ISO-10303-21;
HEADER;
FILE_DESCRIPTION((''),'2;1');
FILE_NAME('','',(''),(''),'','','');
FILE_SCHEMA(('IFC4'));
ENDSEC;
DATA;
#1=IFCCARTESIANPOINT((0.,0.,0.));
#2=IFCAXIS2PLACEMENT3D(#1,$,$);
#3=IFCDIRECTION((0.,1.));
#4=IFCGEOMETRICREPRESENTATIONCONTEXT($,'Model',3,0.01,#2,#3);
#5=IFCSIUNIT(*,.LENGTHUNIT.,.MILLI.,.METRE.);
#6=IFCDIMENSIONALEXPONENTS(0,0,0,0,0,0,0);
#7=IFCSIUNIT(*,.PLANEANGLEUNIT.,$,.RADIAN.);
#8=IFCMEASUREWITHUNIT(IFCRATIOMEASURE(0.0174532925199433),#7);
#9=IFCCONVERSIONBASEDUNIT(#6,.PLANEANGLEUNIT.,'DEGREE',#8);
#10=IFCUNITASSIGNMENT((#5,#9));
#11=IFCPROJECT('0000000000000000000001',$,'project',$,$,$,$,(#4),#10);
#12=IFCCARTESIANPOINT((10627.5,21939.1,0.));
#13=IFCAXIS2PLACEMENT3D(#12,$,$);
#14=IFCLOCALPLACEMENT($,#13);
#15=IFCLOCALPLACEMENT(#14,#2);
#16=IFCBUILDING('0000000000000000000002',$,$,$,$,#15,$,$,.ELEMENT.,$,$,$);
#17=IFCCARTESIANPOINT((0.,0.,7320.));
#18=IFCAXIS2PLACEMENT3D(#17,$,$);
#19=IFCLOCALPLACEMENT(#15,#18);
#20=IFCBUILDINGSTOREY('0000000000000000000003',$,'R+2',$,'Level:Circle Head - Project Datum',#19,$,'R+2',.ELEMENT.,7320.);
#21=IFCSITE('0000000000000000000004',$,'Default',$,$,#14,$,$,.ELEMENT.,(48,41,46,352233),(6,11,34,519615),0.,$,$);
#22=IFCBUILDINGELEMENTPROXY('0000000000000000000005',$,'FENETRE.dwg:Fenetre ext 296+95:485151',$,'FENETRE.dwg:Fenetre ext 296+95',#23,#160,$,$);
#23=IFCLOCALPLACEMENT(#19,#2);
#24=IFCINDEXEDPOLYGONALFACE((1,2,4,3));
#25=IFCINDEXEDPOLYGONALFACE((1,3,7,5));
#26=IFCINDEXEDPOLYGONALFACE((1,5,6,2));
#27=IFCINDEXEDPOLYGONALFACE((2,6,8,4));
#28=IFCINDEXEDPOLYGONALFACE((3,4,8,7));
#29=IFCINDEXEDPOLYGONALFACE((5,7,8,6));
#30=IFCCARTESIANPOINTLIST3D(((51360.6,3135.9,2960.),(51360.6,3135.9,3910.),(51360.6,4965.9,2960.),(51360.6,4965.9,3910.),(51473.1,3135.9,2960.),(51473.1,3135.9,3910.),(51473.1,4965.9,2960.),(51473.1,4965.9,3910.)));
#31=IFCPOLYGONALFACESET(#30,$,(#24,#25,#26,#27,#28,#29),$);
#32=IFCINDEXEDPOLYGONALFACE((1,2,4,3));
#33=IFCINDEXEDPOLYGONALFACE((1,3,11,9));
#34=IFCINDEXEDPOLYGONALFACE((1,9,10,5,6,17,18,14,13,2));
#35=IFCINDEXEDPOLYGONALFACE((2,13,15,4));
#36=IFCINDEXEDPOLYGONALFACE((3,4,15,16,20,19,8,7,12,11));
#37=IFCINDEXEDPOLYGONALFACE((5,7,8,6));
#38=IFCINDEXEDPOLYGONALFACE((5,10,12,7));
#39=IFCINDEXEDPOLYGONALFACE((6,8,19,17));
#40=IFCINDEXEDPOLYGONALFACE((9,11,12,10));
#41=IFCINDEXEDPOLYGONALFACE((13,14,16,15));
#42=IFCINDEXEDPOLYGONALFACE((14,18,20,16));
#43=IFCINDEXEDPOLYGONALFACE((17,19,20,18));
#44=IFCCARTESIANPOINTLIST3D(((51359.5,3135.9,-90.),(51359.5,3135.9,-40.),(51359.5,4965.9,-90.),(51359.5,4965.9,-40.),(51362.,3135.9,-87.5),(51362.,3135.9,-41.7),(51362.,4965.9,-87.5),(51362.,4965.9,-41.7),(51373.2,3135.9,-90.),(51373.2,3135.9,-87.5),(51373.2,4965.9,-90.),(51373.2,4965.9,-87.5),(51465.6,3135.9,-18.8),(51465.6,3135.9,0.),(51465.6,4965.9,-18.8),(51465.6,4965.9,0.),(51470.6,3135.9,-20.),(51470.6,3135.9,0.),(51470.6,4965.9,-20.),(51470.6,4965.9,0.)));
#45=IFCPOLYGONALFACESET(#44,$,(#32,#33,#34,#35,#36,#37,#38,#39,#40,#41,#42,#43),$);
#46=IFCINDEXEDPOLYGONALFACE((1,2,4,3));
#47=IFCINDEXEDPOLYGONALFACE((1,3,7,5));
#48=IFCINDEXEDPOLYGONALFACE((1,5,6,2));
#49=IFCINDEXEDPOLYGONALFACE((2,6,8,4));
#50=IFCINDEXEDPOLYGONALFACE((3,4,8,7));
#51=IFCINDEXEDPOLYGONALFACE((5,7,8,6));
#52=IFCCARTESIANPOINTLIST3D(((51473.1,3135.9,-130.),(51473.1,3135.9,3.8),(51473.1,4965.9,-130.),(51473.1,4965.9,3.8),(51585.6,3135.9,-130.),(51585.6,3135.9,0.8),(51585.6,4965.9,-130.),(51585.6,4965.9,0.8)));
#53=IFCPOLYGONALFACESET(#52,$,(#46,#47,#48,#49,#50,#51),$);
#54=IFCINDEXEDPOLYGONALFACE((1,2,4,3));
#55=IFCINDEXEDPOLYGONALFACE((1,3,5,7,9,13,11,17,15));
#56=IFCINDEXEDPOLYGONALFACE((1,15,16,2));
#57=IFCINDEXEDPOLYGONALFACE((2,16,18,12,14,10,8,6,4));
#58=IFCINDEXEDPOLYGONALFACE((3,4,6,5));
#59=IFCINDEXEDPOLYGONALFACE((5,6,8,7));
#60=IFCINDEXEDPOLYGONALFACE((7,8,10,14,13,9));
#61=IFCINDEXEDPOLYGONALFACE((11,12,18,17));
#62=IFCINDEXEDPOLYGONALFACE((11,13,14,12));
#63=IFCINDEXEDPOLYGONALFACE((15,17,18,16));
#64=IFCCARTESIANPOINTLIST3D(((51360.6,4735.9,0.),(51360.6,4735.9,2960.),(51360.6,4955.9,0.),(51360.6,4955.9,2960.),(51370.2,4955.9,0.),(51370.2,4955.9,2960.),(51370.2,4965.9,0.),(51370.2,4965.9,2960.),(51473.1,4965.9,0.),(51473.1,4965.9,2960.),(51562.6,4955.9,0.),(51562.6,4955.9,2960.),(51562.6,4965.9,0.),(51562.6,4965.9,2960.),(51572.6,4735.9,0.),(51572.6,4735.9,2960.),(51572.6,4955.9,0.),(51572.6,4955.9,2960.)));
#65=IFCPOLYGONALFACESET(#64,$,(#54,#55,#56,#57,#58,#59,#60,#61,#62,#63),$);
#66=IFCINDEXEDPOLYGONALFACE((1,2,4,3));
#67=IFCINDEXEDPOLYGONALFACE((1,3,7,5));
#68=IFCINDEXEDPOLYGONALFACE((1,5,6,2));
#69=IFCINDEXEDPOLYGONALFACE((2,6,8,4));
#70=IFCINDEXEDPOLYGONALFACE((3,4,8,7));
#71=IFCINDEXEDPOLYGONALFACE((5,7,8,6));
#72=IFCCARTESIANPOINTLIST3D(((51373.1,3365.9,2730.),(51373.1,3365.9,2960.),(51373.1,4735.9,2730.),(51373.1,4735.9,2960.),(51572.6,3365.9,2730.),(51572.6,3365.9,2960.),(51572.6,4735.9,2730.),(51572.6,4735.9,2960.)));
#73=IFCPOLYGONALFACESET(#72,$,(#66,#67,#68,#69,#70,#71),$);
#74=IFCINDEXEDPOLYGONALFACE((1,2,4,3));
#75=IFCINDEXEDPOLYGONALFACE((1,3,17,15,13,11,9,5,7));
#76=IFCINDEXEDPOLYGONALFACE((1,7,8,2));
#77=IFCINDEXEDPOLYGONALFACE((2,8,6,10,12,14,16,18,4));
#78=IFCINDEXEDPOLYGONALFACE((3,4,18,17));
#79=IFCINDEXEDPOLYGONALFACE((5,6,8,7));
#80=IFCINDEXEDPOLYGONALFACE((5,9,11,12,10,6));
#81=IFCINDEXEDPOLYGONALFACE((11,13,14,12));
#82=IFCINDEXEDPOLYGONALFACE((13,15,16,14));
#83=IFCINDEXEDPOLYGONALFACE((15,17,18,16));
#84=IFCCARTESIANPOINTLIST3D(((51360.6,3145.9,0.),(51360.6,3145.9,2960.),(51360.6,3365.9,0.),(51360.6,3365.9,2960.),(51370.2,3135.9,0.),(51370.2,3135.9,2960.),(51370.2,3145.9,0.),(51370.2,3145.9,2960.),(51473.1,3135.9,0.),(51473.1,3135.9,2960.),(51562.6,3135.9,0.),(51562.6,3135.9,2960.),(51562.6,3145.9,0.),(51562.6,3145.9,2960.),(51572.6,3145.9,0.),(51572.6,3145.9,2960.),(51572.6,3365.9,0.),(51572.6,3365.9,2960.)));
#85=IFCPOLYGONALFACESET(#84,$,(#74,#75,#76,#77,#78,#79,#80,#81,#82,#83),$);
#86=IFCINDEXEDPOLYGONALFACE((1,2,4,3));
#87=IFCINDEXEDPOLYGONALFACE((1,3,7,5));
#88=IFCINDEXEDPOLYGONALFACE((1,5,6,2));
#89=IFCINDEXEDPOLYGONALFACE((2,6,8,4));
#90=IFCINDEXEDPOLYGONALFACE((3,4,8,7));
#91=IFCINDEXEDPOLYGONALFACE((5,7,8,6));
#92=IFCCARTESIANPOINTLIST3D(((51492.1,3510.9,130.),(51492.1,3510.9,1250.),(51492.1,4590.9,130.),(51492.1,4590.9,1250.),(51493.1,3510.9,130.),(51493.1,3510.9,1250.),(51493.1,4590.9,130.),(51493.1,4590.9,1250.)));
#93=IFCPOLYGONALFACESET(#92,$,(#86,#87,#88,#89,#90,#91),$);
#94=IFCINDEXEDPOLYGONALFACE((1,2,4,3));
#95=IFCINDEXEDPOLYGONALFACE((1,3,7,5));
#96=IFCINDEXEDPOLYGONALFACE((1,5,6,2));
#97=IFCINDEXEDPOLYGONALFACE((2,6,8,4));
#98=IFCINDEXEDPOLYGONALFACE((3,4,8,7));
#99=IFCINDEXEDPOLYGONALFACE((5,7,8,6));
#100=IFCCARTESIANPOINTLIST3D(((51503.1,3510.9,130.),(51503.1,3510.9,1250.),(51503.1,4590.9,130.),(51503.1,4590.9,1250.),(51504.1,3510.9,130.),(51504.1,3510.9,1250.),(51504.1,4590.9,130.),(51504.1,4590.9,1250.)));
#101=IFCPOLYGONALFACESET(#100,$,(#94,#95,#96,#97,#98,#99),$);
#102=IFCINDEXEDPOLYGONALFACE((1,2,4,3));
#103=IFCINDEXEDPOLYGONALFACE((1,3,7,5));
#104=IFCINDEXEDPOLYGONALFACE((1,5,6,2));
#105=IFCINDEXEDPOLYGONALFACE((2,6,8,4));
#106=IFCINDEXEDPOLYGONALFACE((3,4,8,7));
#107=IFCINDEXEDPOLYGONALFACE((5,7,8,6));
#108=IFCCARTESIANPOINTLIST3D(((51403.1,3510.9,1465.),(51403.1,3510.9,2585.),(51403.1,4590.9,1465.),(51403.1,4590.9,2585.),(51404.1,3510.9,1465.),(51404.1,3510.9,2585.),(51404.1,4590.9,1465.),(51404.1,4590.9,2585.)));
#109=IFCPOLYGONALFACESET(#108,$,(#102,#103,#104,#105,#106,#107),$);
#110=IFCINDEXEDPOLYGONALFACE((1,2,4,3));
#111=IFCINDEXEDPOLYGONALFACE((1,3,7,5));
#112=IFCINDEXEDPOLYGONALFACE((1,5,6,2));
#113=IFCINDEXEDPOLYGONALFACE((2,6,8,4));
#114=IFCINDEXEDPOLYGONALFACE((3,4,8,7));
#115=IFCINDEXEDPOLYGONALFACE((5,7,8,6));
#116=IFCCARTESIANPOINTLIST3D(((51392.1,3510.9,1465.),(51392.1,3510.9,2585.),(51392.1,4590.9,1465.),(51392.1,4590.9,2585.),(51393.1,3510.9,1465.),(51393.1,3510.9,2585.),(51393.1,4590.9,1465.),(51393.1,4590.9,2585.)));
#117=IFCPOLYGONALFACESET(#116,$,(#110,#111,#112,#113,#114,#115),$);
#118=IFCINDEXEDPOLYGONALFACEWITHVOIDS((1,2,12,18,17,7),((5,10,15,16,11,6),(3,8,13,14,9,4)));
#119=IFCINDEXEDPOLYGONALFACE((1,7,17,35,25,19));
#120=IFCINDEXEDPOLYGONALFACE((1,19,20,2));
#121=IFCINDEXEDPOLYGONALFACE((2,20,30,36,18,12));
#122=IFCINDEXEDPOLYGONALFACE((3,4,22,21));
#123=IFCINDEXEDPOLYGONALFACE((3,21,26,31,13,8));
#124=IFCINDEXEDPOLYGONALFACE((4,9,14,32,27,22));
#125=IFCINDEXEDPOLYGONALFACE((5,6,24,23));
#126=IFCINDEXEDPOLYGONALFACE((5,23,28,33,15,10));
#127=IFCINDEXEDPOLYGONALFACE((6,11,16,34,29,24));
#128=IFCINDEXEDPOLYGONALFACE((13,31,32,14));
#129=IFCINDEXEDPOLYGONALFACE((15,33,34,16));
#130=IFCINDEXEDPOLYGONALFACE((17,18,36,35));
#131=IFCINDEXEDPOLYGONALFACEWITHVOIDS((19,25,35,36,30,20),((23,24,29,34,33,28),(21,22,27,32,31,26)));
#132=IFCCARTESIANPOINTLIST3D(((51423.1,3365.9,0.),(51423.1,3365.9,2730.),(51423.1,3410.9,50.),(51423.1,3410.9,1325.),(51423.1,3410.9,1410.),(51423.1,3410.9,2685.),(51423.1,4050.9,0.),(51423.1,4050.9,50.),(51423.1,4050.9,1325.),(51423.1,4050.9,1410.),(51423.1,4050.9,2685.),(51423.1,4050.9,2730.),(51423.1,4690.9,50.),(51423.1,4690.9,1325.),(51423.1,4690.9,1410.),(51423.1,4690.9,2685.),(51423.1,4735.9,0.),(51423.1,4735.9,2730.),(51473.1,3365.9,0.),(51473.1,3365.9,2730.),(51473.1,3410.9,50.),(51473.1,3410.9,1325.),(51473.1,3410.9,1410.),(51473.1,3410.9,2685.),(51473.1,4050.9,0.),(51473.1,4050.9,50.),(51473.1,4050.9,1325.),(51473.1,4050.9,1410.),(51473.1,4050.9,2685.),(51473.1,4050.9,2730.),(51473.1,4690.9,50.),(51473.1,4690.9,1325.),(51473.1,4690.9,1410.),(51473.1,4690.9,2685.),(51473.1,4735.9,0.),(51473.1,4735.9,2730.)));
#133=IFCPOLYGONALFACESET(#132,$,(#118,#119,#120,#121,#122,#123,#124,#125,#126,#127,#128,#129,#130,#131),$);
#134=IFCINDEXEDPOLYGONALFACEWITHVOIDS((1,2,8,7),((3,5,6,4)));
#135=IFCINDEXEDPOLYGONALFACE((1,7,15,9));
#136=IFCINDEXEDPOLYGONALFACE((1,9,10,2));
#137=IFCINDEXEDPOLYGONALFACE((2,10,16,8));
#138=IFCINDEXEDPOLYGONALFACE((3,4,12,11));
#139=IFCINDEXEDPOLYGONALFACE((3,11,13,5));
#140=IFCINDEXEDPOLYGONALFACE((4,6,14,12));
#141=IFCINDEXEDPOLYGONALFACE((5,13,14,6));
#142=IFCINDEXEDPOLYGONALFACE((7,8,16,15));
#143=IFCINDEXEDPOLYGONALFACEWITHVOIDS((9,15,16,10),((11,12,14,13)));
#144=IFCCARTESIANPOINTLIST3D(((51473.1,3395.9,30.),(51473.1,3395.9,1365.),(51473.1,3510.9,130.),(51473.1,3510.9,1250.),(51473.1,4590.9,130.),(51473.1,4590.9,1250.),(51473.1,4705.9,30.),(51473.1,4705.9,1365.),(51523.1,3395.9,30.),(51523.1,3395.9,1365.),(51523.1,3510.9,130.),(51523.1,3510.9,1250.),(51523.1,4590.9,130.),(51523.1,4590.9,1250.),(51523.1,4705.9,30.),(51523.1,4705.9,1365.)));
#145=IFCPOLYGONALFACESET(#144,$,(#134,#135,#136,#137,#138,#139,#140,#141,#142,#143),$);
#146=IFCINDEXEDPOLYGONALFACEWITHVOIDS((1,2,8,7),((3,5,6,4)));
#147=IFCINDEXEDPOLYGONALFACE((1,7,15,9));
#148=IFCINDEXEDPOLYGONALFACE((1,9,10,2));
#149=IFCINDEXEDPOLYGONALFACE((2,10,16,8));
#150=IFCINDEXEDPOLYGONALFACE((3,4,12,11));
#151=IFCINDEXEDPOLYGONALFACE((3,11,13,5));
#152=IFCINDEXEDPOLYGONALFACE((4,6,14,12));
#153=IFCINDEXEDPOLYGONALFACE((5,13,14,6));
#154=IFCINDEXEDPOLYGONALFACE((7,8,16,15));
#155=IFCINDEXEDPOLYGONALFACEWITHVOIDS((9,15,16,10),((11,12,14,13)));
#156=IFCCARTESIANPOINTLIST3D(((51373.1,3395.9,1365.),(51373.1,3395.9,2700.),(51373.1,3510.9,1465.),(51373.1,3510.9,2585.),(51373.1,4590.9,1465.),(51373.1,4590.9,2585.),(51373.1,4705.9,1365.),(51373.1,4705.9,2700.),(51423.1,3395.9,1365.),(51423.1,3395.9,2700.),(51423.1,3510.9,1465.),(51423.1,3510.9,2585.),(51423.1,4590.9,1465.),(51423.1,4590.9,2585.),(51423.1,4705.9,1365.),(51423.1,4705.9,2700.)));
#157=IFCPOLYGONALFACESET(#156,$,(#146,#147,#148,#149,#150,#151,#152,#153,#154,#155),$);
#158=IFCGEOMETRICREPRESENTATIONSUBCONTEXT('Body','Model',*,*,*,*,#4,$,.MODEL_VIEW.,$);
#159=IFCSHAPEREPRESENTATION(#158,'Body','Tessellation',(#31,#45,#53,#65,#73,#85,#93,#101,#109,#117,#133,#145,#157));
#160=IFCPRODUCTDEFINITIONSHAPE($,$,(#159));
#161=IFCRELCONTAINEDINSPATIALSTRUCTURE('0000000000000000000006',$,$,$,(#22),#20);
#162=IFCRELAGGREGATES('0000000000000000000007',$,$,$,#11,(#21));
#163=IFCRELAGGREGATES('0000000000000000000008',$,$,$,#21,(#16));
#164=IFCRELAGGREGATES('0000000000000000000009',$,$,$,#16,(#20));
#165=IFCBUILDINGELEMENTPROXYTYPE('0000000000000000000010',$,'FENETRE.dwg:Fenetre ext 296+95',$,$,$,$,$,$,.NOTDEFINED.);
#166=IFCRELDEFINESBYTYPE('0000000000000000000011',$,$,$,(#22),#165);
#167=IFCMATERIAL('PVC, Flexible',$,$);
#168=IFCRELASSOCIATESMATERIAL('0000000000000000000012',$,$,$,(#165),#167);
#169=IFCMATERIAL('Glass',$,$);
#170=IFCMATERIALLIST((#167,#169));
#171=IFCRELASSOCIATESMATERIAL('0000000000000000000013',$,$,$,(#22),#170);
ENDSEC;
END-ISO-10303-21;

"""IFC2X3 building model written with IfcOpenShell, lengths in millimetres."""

from ifc_helpers import new_model, entity, si_unit, converted_unit, direction, frame, frame_2d, origin, origin_2d_with_axis, place, context, subcontext, project, spatial, polyline, rectangle, outline, extrude, source, transform, mapped, material, material_list, type_object, type_shapes, element, save


model = new_model("IFC2X3")

# Units and contexts
model_context = context("Model", 3, precision=0.01, world=origin(), true_north=direction((0.0, 1.0)))
body_context = subcontext(model_context, "Body", "Model", "MODEL_VIEW")
ifc_project = project(units=[si_unit("LENGTHUNIT", "METRE", prefix="MILLI"), converted_unit("PLANEANGLEUNIT", "DEGREE", entity("IfcRatioMeasure", 0.0174532925199433), si_unit("PLANEANGLEUNIT", "RADIAN"), dimensions=[0, 0, 0, 0, 0, 0, 0])], contexts=[model_context])

# Site, building, storey
site_placement = place(None, frame((10627.5, 21939.1, 0.0)))
site = spatial("IfcSite", under=ifc_project, at=site_placement, Name="Default", CompositionType="ELEMENT", RefLatitude=(48, 41, 46, 352233), RefLongitude=(6, 11, 34, 519615), RefElevation=0.0)
building_placement = place(site_placement, origin())
building = spatial("IfcBuilding", under=site, at=building_placement, CompositionType="ELEMENT")
storey_placement = place(building_placement, frame((0.0, 0.0, 7320.0)))
storey = spatial("IfcBuildingStorey", under=building, at=storey_placement, Name="R+2", ObjectType="Level:Circle Head - Project Datum", LongName="R+2", CompositionType="ELEMENT", Elevation=7320.0)

# Building element proxy
ifc_material_1 = material(Name="PVC, Flexible")
ifc_material_2 = material(Name="Glass")
building_element_proxy_type_1 = type_object("IfcBuildingElementProxyType", Name="FENETRE.dwg:Fenetre ext 296+95", PredefinedType="NOTDEFINED", material=ifc_material_1)
shared_shape_1 = source(origin(), body_context, "Body", "SweptSolid", [
    extrude(rectangle(XDim=1830.0, YDim=112.5, at=origin_2d_with_axis()), frame((-10.4, 56.3, 2960.0), z_axis=(0.0, 0.0, 1.0), x_axis=(-1.0, 0.0, 0.0)), (0.0, 0.0, 1.0), 950.0),
    extrude(outline(polyline([(-68.6, -14.4), (-72.5, -34.0), (-67.6, -35.0), (-63.9, -16.6), (44.3, -16.6), (54.1, 32.5), (40.6, 35.2), (40.1, 32.7), (51.2, 30.5), (42.2, -14.4), (-68.6, -14.4)])), frame((-925.4, 66.9, -47.5), z_axis=(-1.0, 0.0, 0.0), x_axis=(0.0, 0.980599, -0.196027)), (0.0, 0.0, -1.0), 1830.0),
    extrude(outline(polyline([(-64.7, -56.3), (66.2, -56.3), (66.2, 56.3), (-67.7, 56.3), (-64.7, -56.3)])), frame((-925.4, -56.3, -63.8), z_axis=(1.0, 0.0, 0.0), x_axis=(0.0, 0.0, -1.0)), (0.0, 0.0, 1.0), 1830.0),
    extrude(outline(polyline([(-55.6, 97.0), (-55.6, -5.9), (-55.6, -95.4), (-45.6, -95.4), (-45.6, -105.4), (174.4, -105.4), (174.4, 106.6), (-45.6, 106.6), (-45.6, 97.0), (-55.6, 97.0)])), frame((849.0, 5.9, 0.0), z_axis=(0.0, 0.0, -1.0), x_axis=(-1.0, 0.0, 0.0)), (0.0, 0.0, -1.0), 2960.0),
    extrude(rectangle(XDim=199.5, YDim=1370.0, at=origin_2d_with_axis()), frame((-10.4, 0.3, 2730.0), z_axis=(0.0, 0.0, 1.0), x_axis=(0.0, 1.0, 0.0)), (0.0, 0.0, 1.0), 230.0),
    extrude(outline(polyline([(-97.0, -55.6), (5.9, -55.6), (95.4, -55.6), (95.4, -45.6), (105.4, -45.6), (105.4, 174.4), (-106.6, 174.4), (-106.6, -45.6), (-97.0, -45.6), (-97.0, -55.6)])), frame((-869.9, 5.9, 0.0), z_axis=(0.0, 0.0, 1.0), x_axis=(0.0, -1.0, 0.0)), (0.0, 0.0, 1.0), 2960.0),
    extrude(rectangle(XDim=1.0, YDim=1080.0, at=origin_2d_with_axis()), frame((-10.4, -19.5, 130.0), z_axis=(0.0, 0.0, 1.0), x_axis=(0.0, 1.0, 0.0)), (0.0, 0.0, 1.0), 1120.0),
    extrude(rectangle(XDim=1.0, YDim=1080.0, at=frame_2d((0.0, 0.0), x_axis=(1.0, 0.0))), frame((-10.4, -30.5, 130.0), z_axis=(0.0, 0.0, 1.0), x_axis=(0.0, 1.0, 0.0)), (0.0, 0.0, 1.0), 1120.0),
    extrude(rectangle(XDim=1.0, YDim=1080.0, at=frame_2d((0.0, 0.0), x_axis=(1.0, 0.0))), frame((-10.4, 69.5, 1465.0), z_axis=(0.0, 0.0, 1.0), x_axis=(0.0, 1.0, 0.0)), (0.0, 0.0, 1.0), 1120.0),
    extrude(rectangle(XDim=1.0, YDim=1080.0, at=frame_2d((0.0, 0.0), x_axis=(1.0, 0.0))), frame((-10.4, 80.5, 1465.0), z_axis=(0.0, 0.0, 1.0), x_axis=(0.0, 1.0, 0.0)), (0.0, 0.0, 1.0), 1120.0),
    extrude(outline(polyline([(-685.0, -1365.0), (0.0, -1365.0), (685.0, -1365.0), (685.0, 1365.0), (0.0, 1365.0), (-685.0, 1365.0), (-685.0, -1365.0)]), holes=[polyline([(-640.0, -1320.0), (-640.0, -45.0), (0.0, -45.0), (640.0, -45.0), (640.0, -1320.0), (0.0, -1320.0), (-640.0, -1320.0)]), polyline([(-640.0, 40.0), (-640.0, 1315.0), (0.0, 1315.0), (640.0, 1315.0), (640.0, 40.0), (0.0, 40.0), (-640.0, 40.0)])]), frame((-10.4, 0.0, 1365.0), z_axis=(0.0, 1.0, 0.0), x_axis=(1.0, 0.0, 0.0)), (0.0, 0.0, 1.0), 50.0),
    extrude(outline(polyline([(-655.0, -667.5), (655.0, -667.5), (655.0, 667.5), (-655.0, 667.5), (-655.0, -667.5)]), holes=[polyline([(-540.0, 552.5), (540.0, 552.5), (540.0, -567.5), (-540.0, -567.5), (-540.0, 552.5)])]), frame((-10.4, -50.0, 697.5), z_axis=(0.0, 1.0, 0.0), x_axis=(-1.0, 0.0, 0.0)), (0.0, 0.0, 1.0), 50.0),
    extrude(outline(polyline([(-655.0, -667.5), (655.0, -667.5), (655.0, 667.5), (-655.0, 667.5), (-655.0, -667.5)]), holes=[polyline([(-540.0, 552.5), (540.0, 552.5), (540.0, -567.5), (-540.0, -567.5), (-540.0, 552.5)])]), frame((-10.4, 50.0, 2032.5), z_axis=(0.0, 1.0, 0.0), x_axis=(-1.0, 0.0, 0.0)), (0.0, 0.0, 1.0), 50.0),
])
type_shapes(building_element_proxy_type_1, [shared_shape_1])
ifc_material_list_1 = material_list([ifc_material_1, ifc_material_2])
proxy_1_placement = place(storey_placement, frame((51473.1, 4061.3, 0.0), z_axis=(0.0, 0.0, 1.0), x_axis=(0.0, 1.0, 0.0)))
element("IfcBuildingElementProxy", 1, at=proxy_1_placement, inside=storey, type_object=building_element_proxy_type_1, material=ifc_material_list_1, Name="FENETRE.dwg:Fenetre ext 296+95:485151", ObjectType="FENETRE.dwg:Fenetre ext 296+95", context=body_context, shape_type="MappedRepresentation", body=[
    mapped(shared_shape_1, transform((0.0, 0.0, 0.0), scale=1.0)),
])

save(model, "model.ifc")
